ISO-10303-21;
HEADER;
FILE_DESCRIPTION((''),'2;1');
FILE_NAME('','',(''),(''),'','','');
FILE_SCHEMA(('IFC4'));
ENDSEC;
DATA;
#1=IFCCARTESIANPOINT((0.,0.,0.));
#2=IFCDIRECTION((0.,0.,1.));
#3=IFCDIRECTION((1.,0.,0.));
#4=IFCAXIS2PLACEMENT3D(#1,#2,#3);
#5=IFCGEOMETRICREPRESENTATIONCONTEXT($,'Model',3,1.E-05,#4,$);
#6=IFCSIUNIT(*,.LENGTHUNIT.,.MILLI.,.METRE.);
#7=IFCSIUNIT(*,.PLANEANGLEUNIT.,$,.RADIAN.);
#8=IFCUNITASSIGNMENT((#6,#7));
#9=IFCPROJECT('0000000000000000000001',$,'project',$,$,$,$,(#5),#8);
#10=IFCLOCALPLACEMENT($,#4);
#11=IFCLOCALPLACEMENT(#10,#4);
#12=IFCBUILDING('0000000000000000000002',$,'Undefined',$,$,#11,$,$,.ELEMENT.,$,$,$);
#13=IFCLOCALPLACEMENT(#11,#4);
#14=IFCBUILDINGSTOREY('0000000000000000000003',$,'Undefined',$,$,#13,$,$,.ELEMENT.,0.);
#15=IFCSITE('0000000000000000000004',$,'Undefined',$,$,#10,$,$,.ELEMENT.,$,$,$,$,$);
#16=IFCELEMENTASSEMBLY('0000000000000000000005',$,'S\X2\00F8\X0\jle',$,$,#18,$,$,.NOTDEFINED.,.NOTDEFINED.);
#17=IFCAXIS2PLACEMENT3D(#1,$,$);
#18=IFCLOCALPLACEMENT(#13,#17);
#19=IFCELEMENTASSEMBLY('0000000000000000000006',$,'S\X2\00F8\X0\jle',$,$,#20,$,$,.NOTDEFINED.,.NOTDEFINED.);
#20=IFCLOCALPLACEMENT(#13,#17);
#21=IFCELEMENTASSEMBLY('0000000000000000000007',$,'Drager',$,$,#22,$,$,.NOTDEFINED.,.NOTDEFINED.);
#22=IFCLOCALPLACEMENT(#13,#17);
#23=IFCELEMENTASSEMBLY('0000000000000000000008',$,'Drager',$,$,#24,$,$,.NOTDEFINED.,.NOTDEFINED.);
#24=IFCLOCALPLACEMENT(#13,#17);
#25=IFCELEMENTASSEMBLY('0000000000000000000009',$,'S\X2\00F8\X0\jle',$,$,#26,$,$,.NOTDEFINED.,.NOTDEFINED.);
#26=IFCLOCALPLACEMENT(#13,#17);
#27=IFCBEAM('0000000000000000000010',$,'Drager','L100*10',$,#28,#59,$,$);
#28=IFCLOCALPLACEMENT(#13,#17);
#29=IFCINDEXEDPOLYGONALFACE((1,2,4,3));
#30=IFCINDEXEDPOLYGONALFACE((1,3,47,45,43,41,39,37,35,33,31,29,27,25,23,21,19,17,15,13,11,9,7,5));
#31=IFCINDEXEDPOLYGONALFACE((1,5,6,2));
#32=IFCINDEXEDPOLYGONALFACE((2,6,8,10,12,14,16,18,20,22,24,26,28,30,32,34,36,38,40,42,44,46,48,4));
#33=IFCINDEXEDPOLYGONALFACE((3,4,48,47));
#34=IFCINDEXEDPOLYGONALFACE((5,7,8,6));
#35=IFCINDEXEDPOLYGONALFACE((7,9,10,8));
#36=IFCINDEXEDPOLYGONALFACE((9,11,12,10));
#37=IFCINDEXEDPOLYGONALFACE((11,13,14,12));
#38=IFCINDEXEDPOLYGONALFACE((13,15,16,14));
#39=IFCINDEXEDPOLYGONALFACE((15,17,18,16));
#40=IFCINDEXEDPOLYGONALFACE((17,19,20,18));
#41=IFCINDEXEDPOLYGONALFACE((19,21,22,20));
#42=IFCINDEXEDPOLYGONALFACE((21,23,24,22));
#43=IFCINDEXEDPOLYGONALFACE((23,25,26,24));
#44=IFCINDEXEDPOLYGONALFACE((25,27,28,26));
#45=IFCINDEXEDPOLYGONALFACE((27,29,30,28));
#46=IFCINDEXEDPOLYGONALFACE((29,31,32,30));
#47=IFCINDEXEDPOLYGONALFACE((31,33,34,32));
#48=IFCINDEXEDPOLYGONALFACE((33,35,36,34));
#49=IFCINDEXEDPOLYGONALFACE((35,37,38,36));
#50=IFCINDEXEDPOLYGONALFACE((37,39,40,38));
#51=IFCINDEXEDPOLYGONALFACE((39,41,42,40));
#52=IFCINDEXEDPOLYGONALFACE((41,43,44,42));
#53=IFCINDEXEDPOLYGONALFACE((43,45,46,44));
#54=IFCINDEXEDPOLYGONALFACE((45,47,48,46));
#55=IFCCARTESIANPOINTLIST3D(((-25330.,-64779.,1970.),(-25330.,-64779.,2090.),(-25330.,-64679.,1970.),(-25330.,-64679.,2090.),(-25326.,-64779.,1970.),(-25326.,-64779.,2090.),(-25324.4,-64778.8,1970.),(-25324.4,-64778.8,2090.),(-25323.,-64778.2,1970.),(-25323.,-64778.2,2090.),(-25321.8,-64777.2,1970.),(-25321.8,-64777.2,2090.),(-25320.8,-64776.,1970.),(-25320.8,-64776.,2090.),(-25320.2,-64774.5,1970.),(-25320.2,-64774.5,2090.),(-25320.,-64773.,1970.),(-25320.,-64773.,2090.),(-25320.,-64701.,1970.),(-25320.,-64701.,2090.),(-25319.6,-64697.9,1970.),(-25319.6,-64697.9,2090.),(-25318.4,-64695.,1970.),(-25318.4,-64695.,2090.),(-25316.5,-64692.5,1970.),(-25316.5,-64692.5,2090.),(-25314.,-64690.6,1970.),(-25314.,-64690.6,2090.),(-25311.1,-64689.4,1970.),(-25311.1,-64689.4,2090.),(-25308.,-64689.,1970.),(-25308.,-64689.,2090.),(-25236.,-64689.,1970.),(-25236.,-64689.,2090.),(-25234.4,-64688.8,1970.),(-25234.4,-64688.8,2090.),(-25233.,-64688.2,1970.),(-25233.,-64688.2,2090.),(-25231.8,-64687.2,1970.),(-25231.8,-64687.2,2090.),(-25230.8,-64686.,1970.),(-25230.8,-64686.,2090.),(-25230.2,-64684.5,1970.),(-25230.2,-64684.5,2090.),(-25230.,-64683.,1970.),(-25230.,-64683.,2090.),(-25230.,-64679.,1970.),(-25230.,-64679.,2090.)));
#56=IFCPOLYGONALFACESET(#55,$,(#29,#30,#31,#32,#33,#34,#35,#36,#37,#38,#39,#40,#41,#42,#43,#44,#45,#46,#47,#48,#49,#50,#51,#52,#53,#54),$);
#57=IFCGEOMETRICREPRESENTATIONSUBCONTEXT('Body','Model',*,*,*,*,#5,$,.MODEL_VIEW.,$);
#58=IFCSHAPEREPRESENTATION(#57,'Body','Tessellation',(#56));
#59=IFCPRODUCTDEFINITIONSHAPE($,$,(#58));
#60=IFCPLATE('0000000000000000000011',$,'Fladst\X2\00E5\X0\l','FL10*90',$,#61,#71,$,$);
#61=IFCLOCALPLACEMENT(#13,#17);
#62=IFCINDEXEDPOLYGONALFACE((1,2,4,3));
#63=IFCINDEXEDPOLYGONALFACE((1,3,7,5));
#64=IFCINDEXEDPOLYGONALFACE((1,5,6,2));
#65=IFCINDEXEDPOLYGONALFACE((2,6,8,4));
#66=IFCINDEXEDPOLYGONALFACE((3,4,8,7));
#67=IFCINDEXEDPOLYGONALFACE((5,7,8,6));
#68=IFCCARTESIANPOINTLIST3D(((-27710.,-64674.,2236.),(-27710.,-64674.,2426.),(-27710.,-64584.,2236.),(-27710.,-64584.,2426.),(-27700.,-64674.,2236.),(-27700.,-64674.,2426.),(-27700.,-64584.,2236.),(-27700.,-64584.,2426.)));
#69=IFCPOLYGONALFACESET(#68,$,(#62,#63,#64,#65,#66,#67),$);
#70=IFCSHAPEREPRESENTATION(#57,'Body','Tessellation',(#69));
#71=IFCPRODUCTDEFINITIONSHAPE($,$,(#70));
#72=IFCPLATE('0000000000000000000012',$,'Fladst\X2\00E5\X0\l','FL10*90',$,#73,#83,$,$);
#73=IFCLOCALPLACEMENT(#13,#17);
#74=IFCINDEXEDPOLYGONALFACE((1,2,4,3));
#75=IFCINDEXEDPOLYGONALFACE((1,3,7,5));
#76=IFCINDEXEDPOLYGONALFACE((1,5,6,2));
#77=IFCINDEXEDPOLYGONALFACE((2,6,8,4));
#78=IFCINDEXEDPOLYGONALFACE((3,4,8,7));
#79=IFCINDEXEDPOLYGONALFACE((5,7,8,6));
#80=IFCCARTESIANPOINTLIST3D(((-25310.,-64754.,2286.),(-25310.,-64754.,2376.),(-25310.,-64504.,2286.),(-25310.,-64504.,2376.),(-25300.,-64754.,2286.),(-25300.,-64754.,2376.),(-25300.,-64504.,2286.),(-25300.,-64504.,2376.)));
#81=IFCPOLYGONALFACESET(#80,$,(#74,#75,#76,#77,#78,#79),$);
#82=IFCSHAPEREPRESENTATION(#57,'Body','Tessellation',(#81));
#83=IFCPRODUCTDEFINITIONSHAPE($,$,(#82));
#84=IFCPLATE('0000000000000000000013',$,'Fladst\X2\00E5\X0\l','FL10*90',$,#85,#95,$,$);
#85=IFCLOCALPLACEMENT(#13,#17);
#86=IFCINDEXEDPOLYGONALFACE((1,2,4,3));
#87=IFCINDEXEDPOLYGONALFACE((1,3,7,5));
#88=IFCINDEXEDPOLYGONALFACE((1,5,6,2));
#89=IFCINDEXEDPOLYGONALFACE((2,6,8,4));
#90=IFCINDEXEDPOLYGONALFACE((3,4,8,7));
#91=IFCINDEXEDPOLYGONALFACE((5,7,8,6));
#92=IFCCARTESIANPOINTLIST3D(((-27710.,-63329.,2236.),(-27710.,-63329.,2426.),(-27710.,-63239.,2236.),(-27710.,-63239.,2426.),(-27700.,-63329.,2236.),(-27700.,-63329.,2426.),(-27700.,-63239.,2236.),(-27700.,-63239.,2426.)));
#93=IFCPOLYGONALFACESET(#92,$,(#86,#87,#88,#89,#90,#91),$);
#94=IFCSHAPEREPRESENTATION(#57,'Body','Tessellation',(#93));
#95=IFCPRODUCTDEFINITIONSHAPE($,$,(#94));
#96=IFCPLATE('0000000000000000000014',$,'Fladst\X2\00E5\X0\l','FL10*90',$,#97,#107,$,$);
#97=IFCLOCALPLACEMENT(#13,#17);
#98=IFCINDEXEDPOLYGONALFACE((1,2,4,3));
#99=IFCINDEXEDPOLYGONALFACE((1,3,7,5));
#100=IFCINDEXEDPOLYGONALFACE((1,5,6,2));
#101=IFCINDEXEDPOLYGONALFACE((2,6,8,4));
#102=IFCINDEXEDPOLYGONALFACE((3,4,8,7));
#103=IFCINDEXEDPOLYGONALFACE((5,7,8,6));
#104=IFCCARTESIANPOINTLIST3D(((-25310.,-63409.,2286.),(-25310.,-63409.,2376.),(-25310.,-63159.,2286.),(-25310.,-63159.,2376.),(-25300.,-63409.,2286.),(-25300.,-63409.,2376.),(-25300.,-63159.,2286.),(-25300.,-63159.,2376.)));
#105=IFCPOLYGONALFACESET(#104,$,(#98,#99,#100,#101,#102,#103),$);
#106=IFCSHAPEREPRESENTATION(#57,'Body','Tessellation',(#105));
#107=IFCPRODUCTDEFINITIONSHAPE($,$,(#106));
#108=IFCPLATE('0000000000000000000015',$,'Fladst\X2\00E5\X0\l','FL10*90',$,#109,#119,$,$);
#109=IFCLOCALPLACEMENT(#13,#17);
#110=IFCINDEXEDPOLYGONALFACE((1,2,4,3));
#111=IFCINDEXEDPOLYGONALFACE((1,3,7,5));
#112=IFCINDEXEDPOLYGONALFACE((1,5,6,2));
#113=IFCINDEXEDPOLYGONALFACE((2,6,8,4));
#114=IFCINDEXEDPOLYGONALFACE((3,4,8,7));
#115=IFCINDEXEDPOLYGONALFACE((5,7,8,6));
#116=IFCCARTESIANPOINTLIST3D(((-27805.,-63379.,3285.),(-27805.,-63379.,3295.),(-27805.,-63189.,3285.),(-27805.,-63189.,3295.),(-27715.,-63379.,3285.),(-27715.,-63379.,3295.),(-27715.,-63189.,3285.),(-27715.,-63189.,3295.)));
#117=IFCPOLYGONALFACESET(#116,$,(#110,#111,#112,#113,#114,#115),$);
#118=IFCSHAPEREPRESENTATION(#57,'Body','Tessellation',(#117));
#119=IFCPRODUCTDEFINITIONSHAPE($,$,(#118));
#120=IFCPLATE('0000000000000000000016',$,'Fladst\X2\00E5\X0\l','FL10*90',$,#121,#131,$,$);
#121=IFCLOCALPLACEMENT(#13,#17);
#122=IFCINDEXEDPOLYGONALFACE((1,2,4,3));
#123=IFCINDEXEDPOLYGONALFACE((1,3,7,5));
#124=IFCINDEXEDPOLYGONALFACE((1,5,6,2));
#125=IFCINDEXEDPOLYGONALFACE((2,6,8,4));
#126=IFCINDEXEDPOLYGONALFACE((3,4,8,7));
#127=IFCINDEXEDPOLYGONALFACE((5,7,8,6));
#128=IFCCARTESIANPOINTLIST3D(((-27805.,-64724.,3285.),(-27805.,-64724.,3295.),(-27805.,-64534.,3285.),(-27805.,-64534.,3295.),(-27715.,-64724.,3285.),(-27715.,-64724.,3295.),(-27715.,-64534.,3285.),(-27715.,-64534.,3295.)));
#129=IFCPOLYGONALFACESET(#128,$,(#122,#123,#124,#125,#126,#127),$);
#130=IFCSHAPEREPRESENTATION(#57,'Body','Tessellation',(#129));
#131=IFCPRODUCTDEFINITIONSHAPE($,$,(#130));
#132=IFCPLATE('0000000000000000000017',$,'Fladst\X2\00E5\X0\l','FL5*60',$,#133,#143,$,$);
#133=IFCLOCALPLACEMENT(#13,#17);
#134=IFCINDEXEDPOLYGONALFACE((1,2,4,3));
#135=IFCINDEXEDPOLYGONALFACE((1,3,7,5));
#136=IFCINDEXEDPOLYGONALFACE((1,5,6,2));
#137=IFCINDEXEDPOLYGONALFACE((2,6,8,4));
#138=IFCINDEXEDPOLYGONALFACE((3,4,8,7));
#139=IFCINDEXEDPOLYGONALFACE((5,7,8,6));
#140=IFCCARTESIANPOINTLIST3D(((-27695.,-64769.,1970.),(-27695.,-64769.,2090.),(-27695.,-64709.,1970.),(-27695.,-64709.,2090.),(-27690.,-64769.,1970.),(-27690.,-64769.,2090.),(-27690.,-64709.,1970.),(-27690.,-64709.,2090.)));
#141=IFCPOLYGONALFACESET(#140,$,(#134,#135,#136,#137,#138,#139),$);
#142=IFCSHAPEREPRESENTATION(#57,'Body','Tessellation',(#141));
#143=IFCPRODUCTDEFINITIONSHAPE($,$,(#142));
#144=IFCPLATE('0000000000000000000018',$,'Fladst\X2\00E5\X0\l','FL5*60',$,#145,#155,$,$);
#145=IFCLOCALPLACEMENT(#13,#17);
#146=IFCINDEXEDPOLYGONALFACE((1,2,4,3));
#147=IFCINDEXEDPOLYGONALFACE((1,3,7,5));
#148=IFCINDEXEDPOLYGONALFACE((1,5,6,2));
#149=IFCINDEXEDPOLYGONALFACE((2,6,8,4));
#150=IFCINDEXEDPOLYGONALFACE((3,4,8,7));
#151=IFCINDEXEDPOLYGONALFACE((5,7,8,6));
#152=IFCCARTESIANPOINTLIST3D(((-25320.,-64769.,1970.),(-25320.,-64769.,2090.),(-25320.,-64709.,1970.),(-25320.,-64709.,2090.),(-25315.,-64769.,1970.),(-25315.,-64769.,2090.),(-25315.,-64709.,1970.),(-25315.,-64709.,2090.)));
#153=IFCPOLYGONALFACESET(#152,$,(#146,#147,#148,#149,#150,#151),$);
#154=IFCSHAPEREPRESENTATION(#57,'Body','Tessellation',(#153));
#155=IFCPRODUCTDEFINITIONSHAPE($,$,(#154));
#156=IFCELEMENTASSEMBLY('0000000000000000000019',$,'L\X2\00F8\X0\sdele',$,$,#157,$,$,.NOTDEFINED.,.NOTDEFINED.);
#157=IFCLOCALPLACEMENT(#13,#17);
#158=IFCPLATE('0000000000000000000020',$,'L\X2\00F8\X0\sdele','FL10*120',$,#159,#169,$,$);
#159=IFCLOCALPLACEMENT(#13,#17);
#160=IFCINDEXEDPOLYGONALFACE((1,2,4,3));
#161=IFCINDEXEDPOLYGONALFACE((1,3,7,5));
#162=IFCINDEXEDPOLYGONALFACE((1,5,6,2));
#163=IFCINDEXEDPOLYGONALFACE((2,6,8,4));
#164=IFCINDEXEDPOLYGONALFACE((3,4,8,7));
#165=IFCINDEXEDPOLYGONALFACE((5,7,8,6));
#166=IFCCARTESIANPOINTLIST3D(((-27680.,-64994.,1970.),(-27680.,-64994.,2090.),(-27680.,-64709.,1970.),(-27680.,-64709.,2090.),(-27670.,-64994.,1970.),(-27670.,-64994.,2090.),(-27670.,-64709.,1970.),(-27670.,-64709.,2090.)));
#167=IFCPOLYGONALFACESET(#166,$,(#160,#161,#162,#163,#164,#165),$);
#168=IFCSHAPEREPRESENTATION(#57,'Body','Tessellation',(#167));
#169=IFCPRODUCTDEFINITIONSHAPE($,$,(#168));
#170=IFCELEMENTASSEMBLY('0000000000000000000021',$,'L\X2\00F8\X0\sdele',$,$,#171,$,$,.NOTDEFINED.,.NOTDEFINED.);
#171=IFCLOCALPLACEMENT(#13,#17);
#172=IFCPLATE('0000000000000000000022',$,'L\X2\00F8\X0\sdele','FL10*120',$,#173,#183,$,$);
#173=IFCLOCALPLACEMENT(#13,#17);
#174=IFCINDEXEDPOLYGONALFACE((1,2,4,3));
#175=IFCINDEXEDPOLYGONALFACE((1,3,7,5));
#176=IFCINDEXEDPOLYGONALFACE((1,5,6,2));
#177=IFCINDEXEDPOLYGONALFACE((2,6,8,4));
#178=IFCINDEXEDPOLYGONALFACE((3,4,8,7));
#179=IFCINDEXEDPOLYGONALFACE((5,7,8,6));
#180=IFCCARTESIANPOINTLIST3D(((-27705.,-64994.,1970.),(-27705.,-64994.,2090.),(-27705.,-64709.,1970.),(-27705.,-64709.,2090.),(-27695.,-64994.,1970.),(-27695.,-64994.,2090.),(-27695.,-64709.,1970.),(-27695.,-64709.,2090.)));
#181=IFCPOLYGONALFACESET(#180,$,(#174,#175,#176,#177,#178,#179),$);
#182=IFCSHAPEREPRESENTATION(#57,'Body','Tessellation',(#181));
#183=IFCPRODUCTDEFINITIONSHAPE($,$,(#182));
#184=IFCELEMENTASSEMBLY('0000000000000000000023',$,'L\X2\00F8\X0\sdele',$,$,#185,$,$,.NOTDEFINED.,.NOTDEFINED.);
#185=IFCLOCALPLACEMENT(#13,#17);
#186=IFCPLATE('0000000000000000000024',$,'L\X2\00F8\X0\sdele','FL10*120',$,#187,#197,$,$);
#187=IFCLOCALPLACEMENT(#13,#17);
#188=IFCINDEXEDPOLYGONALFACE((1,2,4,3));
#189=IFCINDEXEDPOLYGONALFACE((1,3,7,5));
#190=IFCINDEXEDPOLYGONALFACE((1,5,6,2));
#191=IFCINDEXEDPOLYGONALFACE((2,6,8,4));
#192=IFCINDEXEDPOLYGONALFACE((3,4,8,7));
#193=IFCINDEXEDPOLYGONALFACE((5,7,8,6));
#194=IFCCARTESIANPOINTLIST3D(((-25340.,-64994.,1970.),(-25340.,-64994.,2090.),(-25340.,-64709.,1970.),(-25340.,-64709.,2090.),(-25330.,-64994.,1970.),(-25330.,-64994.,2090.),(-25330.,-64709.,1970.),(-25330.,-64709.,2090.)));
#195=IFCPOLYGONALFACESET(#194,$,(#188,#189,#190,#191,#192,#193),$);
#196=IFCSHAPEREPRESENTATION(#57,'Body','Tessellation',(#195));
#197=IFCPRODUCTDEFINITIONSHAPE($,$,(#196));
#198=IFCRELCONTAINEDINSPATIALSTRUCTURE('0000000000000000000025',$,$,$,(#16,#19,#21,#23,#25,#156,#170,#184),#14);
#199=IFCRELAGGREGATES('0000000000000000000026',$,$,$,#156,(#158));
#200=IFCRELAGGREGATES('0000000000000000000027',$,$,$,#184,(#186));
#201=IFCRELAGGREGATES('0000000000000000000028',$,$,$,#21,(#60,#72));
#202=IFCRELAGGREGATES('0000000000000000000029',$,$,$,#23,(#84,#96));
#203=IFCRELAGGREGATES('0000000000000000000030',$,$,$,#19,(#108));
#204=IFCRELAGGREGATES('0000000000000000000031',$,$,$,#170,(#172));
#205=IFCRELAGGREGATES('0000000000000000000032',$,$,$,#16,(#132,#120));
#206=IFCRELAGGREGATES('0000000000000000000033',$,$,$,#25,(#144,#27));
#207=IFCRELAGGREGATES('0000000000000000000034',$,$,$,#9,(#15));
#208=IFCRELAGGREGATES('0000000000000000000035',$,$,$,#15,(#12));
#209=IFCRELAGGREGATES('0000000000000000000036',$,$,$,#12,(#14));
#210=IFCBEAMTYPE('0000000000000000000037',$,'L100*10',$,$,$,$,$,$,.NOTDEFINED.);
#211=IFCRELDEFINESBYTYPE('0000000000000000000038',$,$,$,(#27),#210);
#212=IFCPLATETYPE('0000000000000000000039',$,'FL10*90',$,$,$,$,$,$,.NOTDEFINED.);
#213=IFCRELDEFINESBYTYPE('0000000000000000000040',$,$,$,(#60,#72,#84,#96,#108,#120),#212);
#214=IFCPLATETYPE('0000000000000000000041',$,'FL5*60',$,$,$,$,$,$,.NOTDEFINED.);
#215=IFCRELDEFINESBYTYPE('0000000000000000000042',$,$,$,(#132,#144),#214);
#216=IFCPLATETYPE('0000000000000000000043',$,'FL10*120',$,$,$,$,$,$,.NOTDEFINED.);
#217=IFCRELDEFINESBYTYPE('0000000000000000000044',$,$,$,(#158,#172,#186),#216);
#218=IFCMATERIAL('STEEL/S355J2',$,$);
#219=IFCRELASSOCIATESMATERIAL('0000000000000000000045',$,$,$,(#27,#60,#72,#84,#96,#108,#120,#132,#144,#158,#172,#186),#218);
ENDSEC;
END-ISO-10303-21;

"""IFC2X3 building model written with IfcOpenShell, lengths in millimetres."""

from ifc_helpers import new_model, si_unit, frame, origin_with_axes, origin_2d_with_axis, place, context, subcontext, project, spatial, polyline, l_section, outline, extrude, material, type_object, element, aggregate, save


model = new_model("IFC2X3")

# Units and contexts
model_context = context("Model", 3, precision=1e-05, world=origin_with_axes())
body_context = subcontext(model_context, "Body", "Model", "MODEL_VIEW")
ifc_project = project(units=[si_unit("LENGTHUNIT", "METRE", prefix="MILLI"), si_unit("PLANEANGLEUNIT", "RADIAN")], contexts=[model_context])

# Site, building, storey
site_placement = place(None, origin_with_axes())
site = spatial("IfcSite", under=ifc_project, at=site_placement, Name="Undefined", CompositionType="ELEMENT")
building_placement = place(site_placement, origin_with_axes())
building = spatial("IfcBuilding", under=site, at=building_placement, Name="Undefined", CompositionType="ELEMENT")
storey_placement = place(building_placement, origin_with_axes())
storey = spatial("IfcBuildingStorey", under=building, at=storey_placement, Name="Undefined", CompositionType="ELEMENT", Elevation=0.0)

# Element assemblies
assembly_1_placement = place(storey_placement, origin_with_axes())
assembly_1 = element("IfcElementAssembly", 1, at=assembly_1_placement, inside=storey, Name="Søjle", AssemblyPlace="NOTDEFINED", PredefinedType="NOTDEFINED")
assembly_2_placement = place(storey_placement, origin_with_axes())
assembly_2 = element("IfcElementAssembly", 2, at=assembly_2_placement, inside=storey, Name="Søjle", AssemblyPlace="NOTDEFINED", PredefinedType="NOTDEFINED")

# Element assemblies
assembly_3_placement = place(storey_placement, origin_with_axes())
assembly_3 = element("IfcElementAssembly", 3, at=assembly_3_placement, inside=storey, Name="Drager", AssemblyPlace="NOTDEFINED", PredefinedType="NOTDEFINED")
assembly_4_placement = place(storey_placement, origin_with_axes())
assembly_4 = element("IfcElementAssembly", 4, at=assembly_4_placement, inside=storey, Name="Drager", AssemblyPlace="NOTDEFINED", PredefinedType="NOTDEFINED")

# Shared definitions
ifc_material_1 = material(Name="STEEL/S355J2")
beam_type_1 = type_object("IfcBeamType", Name="L100*10", PredefinedType="NOTDEFINED")

# Element assembly, beam
assembly_5_placement = place(storey_placement, origin_with_axes())
assembly_5 = element("IfcElementAssembly", 5, at=assembly_5_placement, inside=storey, Name="Søjle", AssemblyPlace="NOTDEFINED", PredefinedType="NOTDEFINED")
beam_1_placement = place(assembly_5_placement, frame((-25280.0, -64729.0, 1970.0), z_axis=(0.0, -1.0, 0.0), x_axis=(0.0, 0.0, 1.0)))
beam_1 = element("IfcBeam", 6, at=beam_1_placement, type_object=beam_type_1, material=ifc_material_1, Name="Drager", Description="L100*10", context=body_context, shape_type="SweptSolid", body=[
    extrude(l_section(Depth=100.0, Width=100.0, Thickness=10.0, FilletRadius=12.0, EdgeRadius=6.0, at=origin_2d_with_axis()), frame((120.0, 0.0, 0.0), z_axis=(-1.0, 0.0, 0.0), x_axis=(0.0, -1.0, 0.0)), (0.0, 0.0, 1.0), 120.0),
])

# Plates
plate_type_1 = type_object("IfcPlateType", Name="FL10*90", PredefinedType="NOTDEFINED")
plate_1_placement = place(assembly_3_placement, frame((-27705.0, -64629.0, 2236.0), z_axis=(1.0, 0.0, 0.0), x_axis=(0.0, 0.0, 1.0)))
plate_1 = element("IfcPlate", 7, at=plate_1_placement, type_object=plate_type_1, material=ifc_material_1, Name="Fladstål", Description="FL10*90", context=body_context, shape_type="SweptSolid", body=[
    extrude(outline(polyline([(0.0, -45.0), (0.0, 45.0), (190.0, 45.0), (190.0, -45.0), (0.0, -45.0)])), frame((0.0, 0.0, -5.0), z_axis=(0.0, 0.0, 1.0), x_axis=(1.0, 0.0, 0.0)), (0.0, 0.0, 1.0), 10.0),
])
plate_2_placement = place(assembly_3_placement, frame((-25305.0, -64754.0, 2331.0), z_axis=(-1.0, 0.0, 0.0), x_axis=(0.0, 1.0, 0.0)))
plate_2 = element("IfcPlate", 8, at=plate_2_placement, type_object=plate_type_1, material=ifc_material_1, Name="Fladstål", Description="FL10*90", context=body_context, shape_type="SweptSolid", body=[
    extrude(outline(polyline([(0.0, -45.0), (0.0, 45.0), (250.0, 45.0), (250.0, -45.0), (0.0, -45.0)])), frame((0.0, 0.0, -5.0), z_axis=(0.0, 0.0, 1.0), x_axis=(1.0, 0.0, 0.0)), (0.0, 0.0, 1.0), 10.0),
])
plate_3_placement = place(assembly_4_placement, frame((-27705.0, -63284.0, 2236.0), z_axis=(1.0, 0.0, 0.0), x_axis=(0.0, 0.0, 1.0)))
plate_3 = element("IfcPlate", 9, at=plate_3_placement, type_object=plate_type_1, material=ifc_material_1, Name="Fladstål", Description="FL10*90", context=body_context, shape_type="SweptSolid", body=[
    extrude(outline(polyline([(0.0, -45.0), (0.0, 45.0), (190.0, 45.0), (190.0, -45.0), (0.0, -45.0)])), frame((0.0, 0.0, -5.0), z_axis=(0.0, 0.0, 1.0), x_axis=(1.0, 0.0, 0.0)), (0.0, 0.0, 1.0), 10.0),
])
plate_4_placement = place(assembly_4_placement, frame((-25305.0, -63409.0, 2331.0), z_axis=(-1.0, 0.0, 0.0), x_axis=(0.0, 1.0, 0.0)))
plate_4 = element("IfcPlate", 10, at=plate_4_placement, type_object=plate_type_1, material=ifc_material_1, Name="Fladstål", Description="FL10*90", context=body_context, shape_type="SweptSolid", body=[
    extrude(outline(polyline([(0.0, -45.0), (0.0, 45.0), (250.0, 45.0), (250.0, -45.0), (0.0, -45.0)])), frame((0.0, 0.0, -5.0), z_axis=(0.0, 0.0, 1.0), x_axis=(1.0, 0.0, 0.0)), (0.0, 0.0, 1.0), 10.0),
])
plate_5_placement = place(assembly_2_placement, frame((-27760.0, -63379.0, 3290.0), z_axis=(0.0, 0.0, -1.0), x_axis=(0.0, 1.0, 0.0)))
plate_5 = element("IfcPlate", 11, at=plate_5_placement, type_object=plate_type_1, material=ifc_material_1, Name="Fladstål", Description="FL10*90", context=body_context, shape_type="SweptSolid", body=[
    extrude(outline(polyline([(0.0, -45.0), (0.0, 45.0), (190.0, 45.0), (190.0, -45.0), (0.0, -45.0)])), frame((0.0, 0.0, -5.0), z_axis=(0.0, 0.0, 1.0), x_axis=(1.0, 0.0, 0.0)), (0.0, 0.0, 1.0), 10.0),
])
plate_6_placement = place(assembly_1_placement, frame((-27760.0, -64724.0, 3290.0), z_axis=(0.0, 0.0, -1.0), x_axis=(0.0, 1.0, 0.0)))
plate_6 = element("IfcPlate", 12, at=plate_6_placement, type_object=plate_type_1, material=ifc_material_1, Name="Fladstål", Description="FL10*90", context=body_context, shape_type="SweptSolid", body=[
    extrude(outline(polyline([(0.0, -45.0), (0.0, 45.0), (190.0, 45.0), (190.0, -45.0), (0.0, -45.0)])), frame((0.0, 0.0, -5.0), z_axis=(0.0, 0.0, 1.0), x_axis=(1.0, 0.0, 0.0)), (0.0, 0.0, 1.0), 10.0),
])
plate_type_2 = type_object("IfcPlateType", Name="FL5*60", PredefinedType="NOTDEFINED")
plate_7_placement = place(assembly_1_placement, frame((-27692.5, -64709.0, 2030.0), z_axis=(1.0, -0.00007, 0.0), x_axis=(-0.00007, -1.0, 0.0)))
plate_7 = element("IfcPlate", 13, at=plate_7_placement, type_object=plate_type_2, material=ifc_material_1, Name="Fladstål", Description="FL5*60", context=body_context, shape_type="SweptSolid", body=[
    extrude(outline(polyline([(0.0, -60.0), (0.0, 60.0), (60.0, 60.0), (60.0, -60.0), (0.0, -60.0)])), frame((0.0, 0.0, -2.5), z_axis=(0.0, 0.0, 1.0), x_axis=(1.0, 0.0, 0.0)), (0.0, 0.0, 1.0), 5.0),
])
plate_8_placement = place(assembly_5_placement, frame((-25317.5, -64709.0, 2030.0), z_axis=(1.0, 0.00007, 0.0), x_axis=(0.00007, -1.0, 0.0)))
plate_8 = element("IfcPlate", 14, at=plate_8_placement, type_object=plate_type_2, material=ifc_material_1, Name="Fladstål", Description="FL5*60", context=body_context, shape_type="SweptSolid", body=[
    extrude(outline(polyline([(0.0, -60.0), (0.0, 60.0), (60.0, 60.0), (60.0, -60.0), (0.0, -60.0)])), frame((0.0, 0.0, -2.5), z_axis=(0.0, 0.0, 1.0), x_axis=(1.0, 0.0, 0.0)), (0.0, 0.0, 1.0), 5.0),
])

# Element assemblies, plates
assembly_6_placement = place(storey_placement, origin_with_axes())
assembly_6 = element("IfcElementAssembly", 15, at=assembly_6_placement, inside=storey, Name="Løsdele", AssemblyPlace="NOTDEFINED", PredefinedType="NOTDEFINED")
plate_type_3 = type_object("IfcPlateType", Name="FL10*120", PredefinedType="NOTDEFINED")
plate_9_placement = place(assembly_6_placement, frame((-27675.0, -64994.0, 2030.0), z_axis=(1.0, 0.0, 0.0), x_axis=(0.0, 1.0, 0.0)))
plate_9 = element("IfcPlate", 16, at=plate_9_placement, type_object=plate_type_3, material=ifc_material_1, Name="Løsdele", Description="FL10*120", context=body_context, shape_type="SweptSolid", body=[
    extrude(outline(polyline([(0.0, -60.0), (0.0, 60.0), (285.0, 60.0), (285.0, -60.0), (0.0, -60.0)])), frame((0.0, 0.0, -5.0), z_axis=(0.0, 0.0, 1.0), x_axis=(1.0, 0.0, 0.0)), (0.0, 0.0, 1.0), 10.0),
])
aggregate(assembly_6, [plate_9])
assembly_7_placement = place(storey_placement, origin_with_axes())
assembly_7 = element("IfcElementAssembly", 17, at=assembly_7_placement, inside=storey, Name="Løsdele", AssemblyPlace="NOTDEFINED", PredefinedType="NOTDEFINED")
plate_10_placement = place(assembly_7_placement, frame((-27700.0, -64994.0, 2030.0), z_axis=(1.0, 0.0, 0.0), x_axis=(0.0, 1.0, 0.0)))
plate_10 = element("IfcPlate", 18, at=plate_10_placement, type_object=plate_type_3, material=ifc_material_1, Name="Løsdele", Description="FL10*120", context=body_context, shape_type="SweptSolid", body=[
    extrude(outline(polyline([(0.0, -60.0), (0.0, 60.0), (285.0, 60.0), (285.0, -60.0), (0.0, -60.0)])), frame((0.0, 0.0, -5.0), z_axis=(0.0, 0.0, 1.0), x_axis=(1.0, 0.0, 0.0)), (0.0, 0.0, 1.0), 10.0),
])
assembly_8_placement = place(storey_placement, origin_with_axes())
assembly_8 = element("IfcElementAssembly", 19, at=assembly_8_placement, inside=storey, Name="Løsdele", AssemblyPlace="NOTDEFINED", PredefinedType="NOTDEFINED")
plate_11_placement = place(assembly_8_placement, frame((-25335.0, -64994.0, 2030.0), z_axis=(1.0, 0.0, 0.0), x_axis=(0.0, 1.0, 0.0)))
plate_11 = element("IfcPlate", 20, at=plate_11_placement, type_object=plate_type_3, material=ifc_material_1, Name="Løsdele", Description="FL10*120", context=body_context, shape_type="SweptSolid", body=[
    extrude(outline(polyline([(0.0, -60.0), (0.0, 60.0), (285.0, 60.0), (285.0, -60.0), (0.0, -60.0)])), frame((0.0, 0.0, -5.0), z_axis=(0.0, 0.0, 1.0), x_axis=(1.0, 0.0, 0.0)), (0.0, 0.0, 1.0), 10.0),
])
aggregate(assembly_8, [plate_11])

aggregate(assembly_3, [plate_1, plate_2])
aggregate(assembly_4, [plate_3, plate_4])
aggregate(assembly_2, [plate_5])
aggregate(assembly_7, [plate_10])
aggregate(assembly_1, [plate_7, plate_6])
aggregate(assembly_5, [plate_8, beam_1])

save(model, "model.ifc")
